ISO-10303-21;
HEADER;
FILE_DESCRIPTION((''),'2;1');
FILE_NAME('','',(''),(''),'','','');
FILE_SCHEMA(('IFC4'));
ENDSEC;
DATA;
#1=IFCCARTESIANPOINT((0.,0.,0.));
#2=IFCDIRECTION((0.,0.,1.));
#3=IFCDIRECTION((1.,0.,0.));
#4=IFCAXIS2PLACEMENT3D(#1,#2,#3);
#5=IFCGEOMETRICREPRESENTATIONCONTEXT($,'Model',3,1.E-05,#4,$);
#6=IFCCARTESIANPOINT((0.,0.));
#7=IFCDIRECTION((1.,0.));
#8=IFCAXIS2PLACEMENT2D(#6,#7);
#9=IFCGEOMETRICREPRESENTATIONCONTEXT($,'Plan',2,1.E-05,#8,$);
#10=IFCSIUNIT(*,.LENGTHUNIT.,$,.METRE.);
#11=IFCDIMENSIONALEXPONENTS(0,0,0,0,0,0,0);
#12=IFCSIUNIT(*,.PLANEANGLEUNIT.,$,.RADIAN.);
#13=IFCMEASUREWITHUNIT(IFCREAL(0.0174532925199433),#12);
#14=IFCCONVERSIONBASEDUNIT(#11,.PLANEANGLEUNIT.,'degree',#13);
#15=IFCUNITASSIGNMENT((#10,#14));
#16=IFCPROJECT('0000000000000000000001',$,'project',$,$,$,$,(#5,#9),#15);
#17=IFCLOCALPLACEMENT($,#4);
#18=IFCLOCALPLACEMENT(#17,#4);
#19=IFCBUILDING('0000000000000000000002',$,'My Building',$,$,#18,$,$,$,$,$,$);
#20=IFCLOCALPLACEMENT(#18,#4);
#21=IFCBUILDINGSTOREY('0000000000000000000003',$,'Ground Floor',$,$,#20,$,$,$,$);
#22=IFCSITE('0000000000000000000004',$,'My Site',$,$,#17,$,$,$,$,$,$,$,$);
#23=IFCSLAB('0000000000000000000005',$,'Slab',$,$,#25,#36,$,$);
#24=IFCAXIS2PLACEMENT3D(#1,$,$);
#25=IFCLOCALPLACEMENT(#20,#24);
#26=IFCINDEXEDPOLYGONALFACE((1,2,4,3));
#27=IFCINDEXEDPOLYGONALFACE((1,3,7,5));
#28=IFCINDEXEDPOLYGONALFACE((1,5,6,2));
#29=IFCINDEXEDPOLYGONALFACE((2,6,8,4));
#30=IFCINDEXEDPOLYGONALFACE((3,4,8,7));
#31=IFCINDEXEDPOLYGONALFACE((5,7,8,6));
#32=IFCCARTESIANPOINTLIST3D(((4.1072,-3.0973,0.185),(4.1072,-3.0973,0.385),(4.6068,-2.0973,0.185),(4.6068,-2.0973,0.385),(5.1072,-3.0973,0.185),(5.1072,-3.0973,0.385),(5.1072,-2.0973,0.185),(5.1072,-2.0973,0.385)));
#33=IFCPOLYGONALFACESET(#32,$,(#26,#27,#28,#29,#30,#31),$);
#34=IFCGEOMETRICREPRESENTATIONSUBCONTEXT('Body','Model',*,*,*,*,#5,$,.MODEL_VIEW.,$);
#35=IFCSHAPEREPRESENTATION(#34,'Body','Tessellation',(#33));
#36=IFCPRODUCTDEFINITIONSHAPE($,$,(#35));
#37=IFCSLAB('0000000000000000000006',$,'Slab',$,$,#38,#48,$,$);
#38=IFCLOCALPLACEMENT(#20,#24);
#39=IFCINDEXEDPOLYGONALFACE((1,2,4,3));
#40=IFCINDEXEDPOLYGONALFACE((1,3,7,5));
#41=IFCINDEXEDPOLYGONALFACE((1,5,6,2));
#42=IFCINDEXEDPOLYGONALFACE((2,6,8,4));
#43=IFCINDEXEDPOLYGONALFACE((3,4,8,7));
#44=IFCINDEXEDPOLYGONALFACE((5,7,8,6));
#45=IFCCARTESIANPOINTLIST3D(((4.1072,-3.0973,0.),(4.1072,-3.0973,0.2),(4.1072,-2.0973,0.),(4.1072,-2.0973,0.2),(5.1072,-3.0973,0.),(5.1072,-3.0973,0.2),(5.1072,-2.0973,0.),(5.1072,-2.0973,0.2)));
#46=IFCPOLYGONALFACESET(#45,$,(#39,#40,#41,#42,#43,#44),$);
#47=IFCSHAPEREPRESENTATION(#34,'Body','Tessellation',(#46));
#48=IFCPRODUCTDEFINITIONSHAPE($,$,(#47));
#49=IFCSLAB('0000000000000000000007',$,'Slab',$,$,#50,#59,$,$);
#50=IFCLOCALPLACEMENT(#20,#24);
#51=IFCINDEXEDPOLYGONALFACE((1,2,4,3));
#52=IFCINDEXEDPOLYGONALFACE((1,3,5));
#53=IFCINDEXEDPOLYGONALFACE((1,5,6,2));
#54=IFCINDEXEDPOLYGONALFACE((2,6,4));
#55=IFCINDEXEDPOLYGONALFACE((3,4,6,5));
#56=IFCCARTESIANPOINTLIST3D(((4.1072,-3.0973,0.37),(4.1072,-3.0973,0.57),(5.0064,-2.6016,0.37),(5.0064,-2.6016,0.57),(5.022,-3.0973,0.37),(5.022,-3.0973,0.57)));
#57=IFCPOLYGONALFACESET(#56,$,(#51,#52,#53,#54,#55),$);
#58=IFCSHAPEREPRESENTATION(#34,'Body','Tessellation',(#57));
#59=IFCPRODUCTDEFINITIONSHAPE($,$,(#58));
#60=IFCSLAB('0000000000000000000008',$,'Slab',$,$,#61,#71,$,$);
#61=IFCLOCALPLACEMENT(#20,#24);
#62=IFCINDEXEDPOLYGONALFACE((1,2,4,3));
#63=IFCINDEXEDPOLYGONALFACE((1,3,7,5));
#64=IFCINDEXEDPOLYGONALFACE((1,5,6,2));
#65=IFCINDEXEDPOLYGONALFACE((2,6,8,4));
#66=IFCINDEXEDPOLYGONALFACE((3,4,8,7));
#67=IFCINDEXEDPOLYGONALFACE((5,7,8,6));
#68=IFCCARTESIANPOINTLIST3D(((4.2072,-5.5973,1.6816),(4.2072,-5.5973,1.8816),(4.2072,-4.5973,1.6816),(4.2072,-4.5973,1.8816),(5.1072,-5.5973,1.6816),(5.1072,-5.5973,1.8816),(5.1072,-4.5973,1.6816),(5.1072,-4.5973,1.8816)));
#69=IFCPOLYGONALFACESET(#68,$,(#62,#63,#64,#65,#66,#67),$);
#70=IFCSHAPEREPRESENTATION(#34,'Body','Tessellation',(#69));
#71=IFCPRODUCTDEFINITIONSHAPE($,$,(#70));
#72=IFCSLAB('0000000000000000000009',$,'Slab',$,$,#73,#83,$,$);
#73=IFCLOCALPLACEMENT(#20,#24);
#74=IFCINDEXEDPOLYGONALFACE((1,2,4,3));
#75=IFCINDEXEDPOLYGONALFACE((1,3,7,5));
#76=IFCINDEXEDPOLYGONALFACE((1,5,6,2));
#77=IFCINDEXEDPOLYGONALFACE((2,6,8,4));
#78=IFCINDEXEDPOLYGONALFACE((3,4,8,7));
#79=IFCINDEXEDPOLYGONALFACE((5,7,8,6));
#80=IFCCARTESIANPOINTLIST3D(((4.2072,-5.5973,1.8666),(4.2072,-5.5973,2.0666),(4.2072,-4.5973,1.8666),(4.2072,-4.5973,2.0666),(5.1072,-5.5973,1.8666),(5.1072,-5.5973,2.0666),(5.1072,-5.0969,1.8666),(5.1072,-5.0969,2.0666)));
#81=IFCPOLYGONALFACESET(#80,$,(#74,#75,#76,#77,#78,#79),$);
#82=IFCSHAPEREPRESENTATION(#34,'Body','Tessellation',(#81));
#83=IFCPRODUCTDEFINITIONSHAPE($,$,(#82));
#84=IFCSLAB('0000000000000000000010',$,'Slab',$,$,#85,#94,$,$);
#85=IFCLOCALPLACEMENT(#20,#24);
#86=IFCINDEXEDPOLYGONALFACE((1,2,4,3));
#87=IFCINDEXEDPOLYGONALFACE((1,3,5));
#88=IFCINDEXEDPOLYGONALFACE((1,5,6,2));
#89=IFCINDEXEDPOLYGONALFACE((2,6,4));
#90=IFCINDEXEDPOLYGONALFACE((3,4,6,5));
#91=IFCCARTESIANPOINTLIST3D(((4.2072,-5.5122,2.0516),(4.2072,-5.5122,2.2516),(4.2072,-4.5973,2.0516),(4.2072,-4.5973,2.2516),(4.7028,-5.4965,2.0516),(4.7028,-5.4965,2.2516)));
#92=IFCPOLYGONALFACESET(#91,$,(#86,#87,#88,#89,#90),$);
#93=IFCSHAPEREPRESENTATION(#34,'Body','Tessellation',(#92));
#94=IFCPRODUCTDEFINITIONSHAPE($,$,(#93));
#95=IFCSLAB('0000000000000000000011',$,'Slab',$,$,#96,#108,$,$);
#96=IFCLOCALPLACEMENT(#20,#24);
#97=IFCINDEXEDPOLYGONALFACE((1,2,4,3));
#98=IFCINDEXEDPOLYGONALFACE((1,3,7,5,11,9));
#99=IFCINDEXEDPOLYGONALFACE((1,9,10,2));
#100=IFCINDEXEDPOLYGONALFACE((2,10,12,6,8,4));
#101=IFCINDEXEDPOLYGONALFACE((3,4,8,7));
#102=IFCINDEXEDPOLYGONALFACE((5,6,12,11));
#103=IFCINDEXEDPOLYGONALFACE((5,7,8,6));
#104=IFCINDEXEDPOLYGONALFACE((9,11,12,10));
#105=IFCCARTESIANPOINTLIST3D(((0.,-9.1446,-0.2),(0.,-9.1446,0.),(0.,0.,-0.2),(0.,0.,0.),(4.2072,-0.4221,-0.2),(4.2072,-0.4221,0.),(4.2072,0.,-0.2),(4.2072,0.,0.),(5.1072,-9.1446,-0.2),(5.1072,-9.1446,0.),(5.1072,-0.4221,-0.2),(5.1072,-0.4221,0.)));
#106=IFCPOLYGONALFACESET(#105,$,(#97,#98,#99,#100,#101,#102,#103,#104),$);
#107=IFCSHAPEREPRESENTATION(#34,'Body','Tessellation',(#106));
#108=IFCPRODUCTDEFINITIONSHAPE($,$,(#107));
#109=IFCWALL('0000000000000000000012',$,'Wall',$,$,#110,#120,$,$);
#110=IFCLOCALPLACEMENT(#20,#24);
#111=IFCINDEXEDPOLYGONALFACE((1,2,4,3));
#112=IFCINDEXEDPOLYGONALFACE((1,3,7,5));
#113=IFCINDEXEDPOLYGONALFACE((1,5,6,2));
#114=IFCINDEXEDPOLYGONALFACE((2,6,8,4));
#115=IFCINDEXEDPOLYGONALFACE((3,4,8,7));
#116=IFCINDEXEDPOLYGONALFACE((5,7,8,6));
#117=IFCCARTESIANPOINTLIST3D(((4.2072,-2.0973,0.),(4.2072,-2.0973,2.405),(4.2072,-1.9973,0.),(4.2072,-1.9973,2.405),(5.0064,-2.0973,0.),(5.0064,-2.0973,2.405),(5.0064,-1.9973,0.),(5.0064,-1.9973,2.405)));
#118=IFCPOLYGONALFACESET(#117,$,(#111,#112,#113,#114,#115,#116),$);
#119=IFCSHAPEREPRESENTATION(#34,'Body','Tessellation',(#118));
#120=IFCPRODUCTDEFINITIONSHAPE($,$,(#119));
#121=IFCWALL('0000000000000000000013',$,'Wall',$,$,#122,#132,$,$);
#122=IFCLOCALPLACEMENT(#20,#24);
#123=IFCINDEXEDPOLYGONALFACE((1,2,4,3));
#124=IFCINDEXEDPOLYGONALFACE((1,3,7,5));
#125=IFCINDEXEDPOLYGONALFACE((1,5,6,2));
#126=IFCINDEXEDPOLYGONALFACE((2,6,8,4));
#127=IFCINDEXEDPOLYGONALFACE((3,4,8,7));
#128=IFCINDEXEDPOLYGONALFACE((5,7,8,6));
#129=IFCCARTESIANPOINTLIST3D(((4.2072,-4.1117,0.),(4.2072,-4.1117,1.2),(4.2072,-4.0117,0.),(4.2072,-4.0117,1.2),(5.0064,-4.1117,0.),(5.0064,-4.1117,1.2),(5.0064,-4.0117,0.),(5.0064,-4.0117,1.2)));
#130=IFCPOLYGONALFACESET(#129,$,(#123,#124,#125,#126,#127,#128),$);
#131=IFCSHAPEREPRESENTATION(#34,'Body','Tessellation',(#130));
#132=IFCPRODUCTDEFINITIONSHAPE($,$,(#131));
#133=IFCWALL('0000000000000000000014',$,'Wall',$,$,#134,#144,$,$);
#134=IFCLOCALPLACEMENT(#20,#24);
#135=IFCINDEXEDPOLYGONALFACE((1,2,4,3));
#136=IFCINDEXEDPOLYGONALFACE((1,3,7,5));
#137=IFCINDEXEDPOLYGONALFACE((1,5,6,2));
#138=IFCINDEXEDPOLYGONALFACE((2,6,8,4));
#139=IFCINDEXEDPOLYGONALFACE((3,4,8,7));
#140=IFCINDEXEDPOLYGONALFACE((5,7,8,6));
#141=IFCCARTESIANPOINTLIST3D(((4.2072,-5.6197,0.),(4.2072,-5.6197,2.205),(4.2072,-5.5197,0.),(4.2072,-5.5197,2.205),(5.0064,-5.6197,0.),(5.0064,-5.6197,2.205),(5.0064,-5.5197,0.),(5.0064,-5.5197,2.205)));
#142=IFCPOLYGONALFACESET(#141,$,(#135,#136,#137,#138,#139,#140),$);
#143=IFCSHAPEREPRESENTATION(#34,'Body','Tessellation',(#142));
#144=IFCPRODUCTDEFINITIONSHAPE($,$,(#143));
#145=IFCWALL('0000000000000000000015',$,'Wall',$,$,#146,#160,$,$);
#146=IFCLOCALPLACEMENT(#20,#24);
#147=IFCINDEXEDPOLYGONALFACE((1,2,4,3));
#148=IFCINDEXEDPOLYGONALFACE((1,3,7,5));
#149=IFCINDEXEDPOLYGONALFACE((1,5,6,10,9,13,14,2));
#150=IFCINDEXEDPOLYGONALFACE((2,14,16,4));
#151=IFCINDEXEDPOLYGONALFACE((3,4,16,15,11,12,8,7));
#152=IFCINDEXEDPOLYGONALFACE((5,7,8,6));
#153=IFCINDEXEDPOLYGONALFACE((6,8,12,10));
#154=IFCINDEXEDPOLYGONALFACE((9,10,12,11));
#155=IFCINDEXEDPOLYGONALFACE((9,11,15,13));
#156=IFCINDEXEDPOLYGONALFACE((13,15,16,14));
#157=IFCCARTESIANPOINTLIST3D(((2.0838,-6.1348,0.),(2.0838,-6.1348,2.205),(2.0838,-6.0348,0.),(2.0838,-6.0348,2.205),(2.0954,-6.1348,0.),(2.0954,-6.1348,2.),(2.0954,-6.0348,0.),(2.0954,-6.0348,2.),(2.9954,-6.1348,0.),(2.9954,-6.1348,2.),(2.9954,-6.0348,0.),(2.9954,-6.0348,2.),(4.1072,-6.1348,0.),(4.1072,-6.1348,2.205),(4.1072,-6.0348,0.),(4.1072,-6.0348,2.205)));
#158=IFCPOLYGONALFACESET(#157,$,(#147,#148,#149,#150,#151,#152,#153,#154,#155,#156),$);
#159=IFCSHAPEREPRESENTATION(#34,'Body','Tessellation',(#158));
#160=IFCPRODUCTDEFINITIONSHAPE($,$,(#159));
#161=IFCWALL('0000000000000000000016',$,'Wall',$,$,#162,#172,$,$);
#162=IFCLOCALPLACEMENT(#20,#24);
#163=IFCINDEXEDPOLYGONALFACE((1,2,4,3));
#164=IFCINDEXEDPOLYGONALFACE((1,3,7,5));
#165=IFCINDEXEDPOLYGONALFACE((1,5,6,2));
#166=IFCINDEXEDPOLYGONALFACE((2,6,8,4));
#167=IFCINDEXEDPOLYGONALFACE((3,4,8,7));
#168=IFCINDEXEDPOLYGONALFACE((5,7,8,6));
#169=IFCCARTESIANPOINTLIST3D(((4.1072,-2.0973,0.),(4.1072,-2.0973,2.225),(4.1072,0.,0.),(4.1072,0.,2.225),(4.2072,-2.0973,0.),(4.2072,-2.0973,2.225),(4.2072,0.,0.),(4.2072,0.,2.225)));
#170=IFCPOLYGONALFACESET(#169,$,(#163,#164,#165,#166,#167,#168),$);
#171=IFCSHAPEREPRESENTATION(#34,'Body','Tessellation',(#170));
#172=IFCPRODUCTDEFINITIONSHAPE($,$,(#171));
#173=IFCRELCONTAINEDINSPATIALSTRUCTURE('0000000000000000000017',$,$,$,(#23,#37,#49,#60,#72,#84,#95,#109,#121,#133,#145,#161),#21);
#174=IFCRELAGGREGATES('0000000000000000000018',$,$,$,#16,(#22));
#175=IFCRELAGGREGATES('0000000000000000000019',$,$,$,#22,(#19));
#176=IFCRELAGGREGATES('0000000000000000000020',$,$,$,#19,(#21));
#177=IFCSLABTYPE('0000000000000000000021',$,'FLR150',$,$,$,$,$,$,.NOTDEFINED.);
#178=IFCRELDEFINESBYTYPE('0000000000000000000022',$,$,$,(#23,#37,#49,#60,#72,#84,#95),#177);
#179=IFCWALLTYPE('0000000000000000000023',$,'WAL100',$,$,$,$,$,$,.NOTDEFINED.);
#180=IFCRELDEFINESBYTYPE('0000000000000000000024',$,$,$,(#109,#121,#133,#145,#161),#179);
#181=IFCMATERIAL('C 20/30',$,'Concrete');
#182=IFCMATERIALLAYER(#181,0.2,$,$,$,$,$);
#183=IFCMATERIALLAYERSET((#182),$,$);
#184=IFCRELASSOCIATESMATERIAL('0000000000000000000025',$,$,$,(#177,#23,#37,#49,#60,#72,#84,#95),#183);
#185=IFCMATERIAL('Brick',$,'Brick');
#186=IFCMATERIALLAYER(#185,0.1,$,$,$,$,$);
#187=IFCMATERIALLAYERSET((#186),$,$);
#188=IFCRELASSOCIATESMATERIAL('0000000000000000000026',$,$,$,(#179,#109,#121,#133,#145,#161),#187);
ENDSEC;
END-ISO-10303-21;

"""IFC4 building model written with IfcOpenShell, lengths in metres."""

from ifc_helpers import new_model, entity, si_unit, converted_unit, frame, origin_with_axes, origin_2d_with_axis, place, context, subcontext, project, spatial, line, indexed_curve, outline, extrude, source, transform, mapped, material, layer, layer_set, layer_usage, type_object, element, save


model = new_model("IFC4")

# Units and contexts
model_context = context("Model", 3, precision=1e-05, world=origin_with_axes())
plan_context = context("Plan", 2, precision=1e-05, world=origin_2d_with_axis())
body_context = subcontext(model_context, "Body", "Model", "MODEL_VIEW")
ifc_project = project(units=[si_unit("LENGTHUNIT", "METRE"), converted_unit("PLANEANGLEUNIT", "degree", entity("IfcReal", 0.0174532925199433), si_unit("PLANEANGLEUNIT", "RADIAN"), dimensions=[0, 0, 0, 0, 0, 0, 0])], contexts=[model_context, plan_context])

# Site, building, storey
site_placement = place(None, origin_with_axes())
site = spatial("IfcSite", under=ifc_project, at=site_placement, Name="My Site")
building_placement = place(site_placement, origin_with_axes())
building = spatial("IfcBuilding", under=site, at=building_placement, Name="My Building")
storey_placement = place(building_placement, origin_with_axes())
storey = spatial("IfcBuildingStorey", under=building, at=storey_placement, Name="Ground Floor")

# Slabs
ifc_material_1 = material(Name="C 20/30", Category="Concrete")
ifc_layer_1 = layer(ifc_material_1, 0.2)
ifc_layer_set_1 = layer_set([ifc_layer_1])
ifc_layer_usage_1 = layer_usage(ifc_layer_set_1, "AXIS3", "POSITIVE", 0.0)
slab_type = type_object("IfcSlabType", Name="FLR150", PredefinedType="NOTDEFINED", material=ifc_layer_set_1)
slab_1_placement = place(storey_placement, frame((4.1072, -3.0973, 0.185), z_axis=(0.0, 0.0, 1.0), x_axis=(1.0, 0.0, 0.0)))
element("IfcSlab", 1, at=slab_1_placement, inside=storey, type_object=slab_type, material=ifc_layer_usage_1, Name="Slab", context=body_context, shape_type="SweptSolid", body=[
    extrude(outline(indexed_curve([(0.0, 0.0), (1.0, 0.0), (1.0, 1.0), (0.4996, 1.0)], segments=[line(3, 2), line(2, 1), line(1, 4), line(4, 3)], self_intersect=False)), None, (0.0, 0.0, 1.0), 0.2),
])
ifc_layer_usage_2 = layer_usage(ifc_layer_set_1, "AXIS3", "POSITIVE", 0.0)
slab_2_placement = place(storey_placement, frame((4.1072, -3.0973, 0.0), z_axis=(0.0, 0.0, 1.0), x_axis=(1.0, 0.0, 0.0)))
element("IfcSlab", 2, at=slab_2_placement, inside=storey, type_object=slab_type, material=ifc_layer_usage_2, Name="Slab", context=body_context, shape_type="SweptSolid", body=[
    extrude(outline(indexed_curve([(0.0, 0.0), (1.0, 0.0), (1.0, 1.0), (0.0, 1.0), (0.0, 0.0)])), None, (0.0, 0.0, 1.0), 0.2),
])
ifc_layer_usage_3 = layer_usage(ifc_layer_set_1, "AXIS3", "POSITIVE", 0.0)
slab_3_placement = place(storey_placement, frame((4.1072, -3.0973, 0.37), z_axis=(0.0, 0.0, 1.0), x_axis=(1.0, 0.0, 0.0)))
element("IfcSlab", 3, at=slab_3_placement, inside=storey, type_object=slab_type, material=ifc_layer_usage_3, Name="Slab", context=body_context, shape_type="SweptSolid", body=[
    extrude(outline(indexed_curve([(0.0, 0.0), (0.9149, 0.0), (0.8992, 0.4957)], segments=[line(1, 3), line(3, 2), line(2, 1)], self_intersect=False)), None, (0.0, 0.0, 1.0), 0.2),
])
ifc_layer_usage_4 = layer_usage(ifc_layer_set_1, "AXIS3", "POSITIVE", 0.0)
slab_4_placement = place(storey_placement, frame((4.2072, -4.5973, 1.6816), z_axis=(0.0, 0.0, 1.0), x_axis=(0.0, -1.0, 0.0)))
element("IfcSlab", 4, at=slab_4_placement, inside=storey, type_object=slab_type, material=ifc_layer_usage_4, Name="Slab", context=body_context, shape_type="SweptSolid", body=[
    extrude(outline(indexed_curve([(0.0, 0.0), (1.0, 0.0), (1.0, 0.9), (0.0, 0.9)], segments=[line(4, 1), line(1, 2), line(2, 3), line(3, 4)], self_intersect=False)), None, (0.0, 0.0, 1.0), 0.2),
])
ifc_layer_usage_5 = layer_usage(ifc_layer_set_1, "AXIS3", "POSITIVE", 0.0)
slab_5_placement = place(storey_placement, frame((4.2072, -4.5973, 1.8666), z_axis=(0.0, 0.0, 1.0), x_axis=(0.0, -1.0, 0.0)))
element("IfcSlab", 5, at=slab_5_placement, inside=storey, type_object=slab_type, material=ifc_layer_usage_5, Name="Slab", context=body_context, shape_type="SweptSolid", body=[
    extrude(outline(indexed_curve([(1.0, 0.0), (1.0, 0.9), (0.4996, 0.9), (0.0, 0.0)], segments=[line(4, 1), line(1, 2), line(2, 3), line(3, 4)], self_intersect=False)), None, (0.0, 0.0, 1.0), 0.2),
])
ifc_layer_usage_6 = layer_usage(ifc_layer_set_1, "AXIS3", "POSITIVE", 0.0)
slab_6_placement = place(storey_placement, frame((4.2072, -4.5973, 2.0516), z_axis=(0.0, 0.0, 1.0), x_axis=(0.0, -1.0, 0.0)))
element("IfcSlab", 6, at=slab_6_placement, inside=storey, type_object=slab_type, material=ifc_layer_usage_6, Name="Slab", context=body_context, shape_type="SweptSolid", body=[
    extrude(outline(indexed_curve([(0.0, 0.0), (0.9149, 0.0), (0.8992, 0.4957)], segments=[line(1, 3), line(3, 2), line(2, 1)], self_intersect=False)), None, (0.0, 0.0, 1.0), 0.2),
])
ifc_layer_usage_7 = layer_usage(ifc_layer_set_1, "AXIS3", "POSITIVE", 0.0)
slab_7_placement = place(storey_placement, frame((0.0, -9.1446, -0.2), z_axis=(0.0, 0.0, 1.0), x_axis=(1.0, 0.0, 0.0)))
element("IfcSlab", 7, at=slab_7_placement, inside=storey, type_object=slab_type, material=ifc_layer_usage_7, Name="Slab", context=body_context, shape_type="SweptSolid", body=[
    extrude(outline(indexed_curve([(4.2072, 8.7225), (5.1072, 0.0), (0.0, 0.0), (0.0, 9.1446), (5.1072, 8.7225), (4.2072, 9.1446)], segments=[line(5, 2), line(2, 3), line(3, 4), line(4, 6), line(6, 1), line(1, 5)], self_intersect=False)), None, (0.0, 0.0, 1.0), 0.2),
])

# Walls
ifc_material_2 = material(Name="Brick", Category="Brick")
ifc_layer_2 = layer(ifc_material_2, 0.1)
ifc_layer_set_2 = layer_set([ifc_layer_2])
ifc_layer_usage_8 = layer_usage(ifc_layer_set_2, "AXIS2", "POSITIVE", 0.0)
wall_type = type_object("IfcWallType", Name="WAL100", PredefinedType="NOTDEFINED", material=ifc_layer_set_2)
wall_1_placement = place(storey_placement, frame((5.0064, -1.9973, 0.0), z_axis=(0.0, 0.0, 1.0), x_axis=(-1.0, 0.000001, 0.0)))
element("IfcWall", 8, at=wall_1_placement, inside=storey, type_object=wall_type, material=ifc_layer_usage_8, Name="Wall", context=body_context, shape_type="SweptSolid", body=[
    extrude(outline(indexed_curve([(0.0, 0.0), (0.0, 0.1), (0.7992, 0.1), (0.7992, 0.0), (0.0, 0.0)], self_intersect=False)), origin_with_axes(), (0.0, 0.0, 1.0), 2.405),
])
ifc_layer_usage_9 = layer_usage(ifc_layer_set_2, "AXIS2", "POSITIVE", 0.0)
wall_2_placement = place(storey_placement, frame((5.0064, -4.0117, 0.0), z_axis=(0.0, 0.0, 1.0), x_axis=(-1.0, 0.000001, 0.0)))
element("IfcWall", 9, at=wall_2_placement, inside=storey, type_object=wall_type, material=ifc_layer_usage_9, Name="Wall", context=body_context, shape_type="SweptSolid", body=[
    extrude(outline(indexed_curve([(0.0, 0.0), (0.0, 0.1), (0.7992, 0.1), (0.7992, 0.0), (0.0, 0.0)], self_intersect=False)), origin_with_axes(), (0.0, 0.0, 1.0), 1.2),
])
ifc_layer_usage_10 = layer_usage(ifc_layer_set_2, "AXIS2", "POSITIVE", 0.0)
wall_3_placement = place(storey_placement, frame((5.0064, -5.5197, 0.0), z_axis=(0.0, 0.0, 1.0), x_axis=(-1.0, 0.000001, 0.0)))
element("IfcWall", 10, at=wall_3_placement, inside=storey, type_object=wall_type, material=ifc_layer_usage_10, Name="Wall", context=body_context, shape_type="SweptSolid", body=[
    extrude(outline(indexed_curve([(0.0, 0.0), (0.0, 0.1), (0.7992, 0.1), (0.7992, 0.0), (0.0, 0.0)], self_intersect=False)), origin_with_axes(), (0.0, 0.0, 1.0), 2.205),
])

# Wall, opening
ifc_layer_usage_11 = layer_usage(ifc_layer_set_2, "AXIS2", "POSITIVE", 0.0)
wall_4_placement = place(storey_placement, frame((2.0838, -6.1348, 0.0), z_axis=(0.0, 0.0, 1.0), x_axis=(1.0, 0.0, 0.0)))
wall_4 = element("IfcWall", 11, at=wall_4_placement, inside=storey, type_object=wall_type, material=ifc_layer_usage_11, Name="Wall", context=body_context, shape_type="SweptSolid", body=[
    extrude(outline(indexed_curve([(0.0, 0.0), (0.0, 0.1), (2.0234, 0.1), (2.0234, 0.0), (0.0, 0.0)], self_intersect=False)), origin_with_axes(), (0.0, 0.0, 1.0), 2.205),
])
shared_shape_1 = source(origin_with_axes(), body_context, "Body", "SweptSolid", [
    extrude(outline(indexed_curve([(0.0, 0.0), (0.9, 0.0), (0.9, 2.0), (0.0, 2.0)], segments=[line(1, 2, 3, 4, 1)])), frame((0.0, -0.1, 0.0), z_axis=(0.0, -1.0, 0.0), x_axis=(1.0, 0.0, 0.0)), (0.0, 0.0, -1.0), 0.3),
])
opening_1_placement = place(wall_4_placement, frame((0.9116, 0.1, 0.0), z_axis=(0.0, 0.0, 1.0), x_axis=(-1.0, 0.0, 0.0)))
element("IfcOpeningElement", 12, at=opening_1_placement, cuts=wall_4, PredefinedType="OPENING", context=body_context, shape_type="MappedRepresentation", body=[
    mapped(shared_shape_1, transform((0.0, 0.0, 0.0), x_axis=(1.0, 0.0, 0.0), y_axis=(0.0, 1.0, 0.0), z_axis=(0.0, 0.0, 1.0), scale=1.0)),
])

# Wall
ifc_layer_usage_12 = layer_usage(ifc_layer_set_2, "AXIS2", "POSITIVE", 0.0)
wall_5_placement = place(storey_placement, frame((4.1072, 0.0, 0.0), z_axis=(0.0, 0.0, 1.0), x_axis=(-0.000001, -1.0, 0.0)))
element("IfcWall", 13, at=wall_5_placement, inside=storey, type_object=wall_type, material=ifc_layer_usage_12, Name="Wall", context=body_context, shape_type="SweptSolid", body=[
    extrude(outline(indexed_curve([(0.0, 0.0), (0.0, 0.1), (2.0973, 0.1), (2.0973, 0.0), (0.0, 0.0)], self_intersect=False)), origin_with_axes(), (0.0, 0.0, 1.0), 2.225),
])

save(model, "model.ifc")
